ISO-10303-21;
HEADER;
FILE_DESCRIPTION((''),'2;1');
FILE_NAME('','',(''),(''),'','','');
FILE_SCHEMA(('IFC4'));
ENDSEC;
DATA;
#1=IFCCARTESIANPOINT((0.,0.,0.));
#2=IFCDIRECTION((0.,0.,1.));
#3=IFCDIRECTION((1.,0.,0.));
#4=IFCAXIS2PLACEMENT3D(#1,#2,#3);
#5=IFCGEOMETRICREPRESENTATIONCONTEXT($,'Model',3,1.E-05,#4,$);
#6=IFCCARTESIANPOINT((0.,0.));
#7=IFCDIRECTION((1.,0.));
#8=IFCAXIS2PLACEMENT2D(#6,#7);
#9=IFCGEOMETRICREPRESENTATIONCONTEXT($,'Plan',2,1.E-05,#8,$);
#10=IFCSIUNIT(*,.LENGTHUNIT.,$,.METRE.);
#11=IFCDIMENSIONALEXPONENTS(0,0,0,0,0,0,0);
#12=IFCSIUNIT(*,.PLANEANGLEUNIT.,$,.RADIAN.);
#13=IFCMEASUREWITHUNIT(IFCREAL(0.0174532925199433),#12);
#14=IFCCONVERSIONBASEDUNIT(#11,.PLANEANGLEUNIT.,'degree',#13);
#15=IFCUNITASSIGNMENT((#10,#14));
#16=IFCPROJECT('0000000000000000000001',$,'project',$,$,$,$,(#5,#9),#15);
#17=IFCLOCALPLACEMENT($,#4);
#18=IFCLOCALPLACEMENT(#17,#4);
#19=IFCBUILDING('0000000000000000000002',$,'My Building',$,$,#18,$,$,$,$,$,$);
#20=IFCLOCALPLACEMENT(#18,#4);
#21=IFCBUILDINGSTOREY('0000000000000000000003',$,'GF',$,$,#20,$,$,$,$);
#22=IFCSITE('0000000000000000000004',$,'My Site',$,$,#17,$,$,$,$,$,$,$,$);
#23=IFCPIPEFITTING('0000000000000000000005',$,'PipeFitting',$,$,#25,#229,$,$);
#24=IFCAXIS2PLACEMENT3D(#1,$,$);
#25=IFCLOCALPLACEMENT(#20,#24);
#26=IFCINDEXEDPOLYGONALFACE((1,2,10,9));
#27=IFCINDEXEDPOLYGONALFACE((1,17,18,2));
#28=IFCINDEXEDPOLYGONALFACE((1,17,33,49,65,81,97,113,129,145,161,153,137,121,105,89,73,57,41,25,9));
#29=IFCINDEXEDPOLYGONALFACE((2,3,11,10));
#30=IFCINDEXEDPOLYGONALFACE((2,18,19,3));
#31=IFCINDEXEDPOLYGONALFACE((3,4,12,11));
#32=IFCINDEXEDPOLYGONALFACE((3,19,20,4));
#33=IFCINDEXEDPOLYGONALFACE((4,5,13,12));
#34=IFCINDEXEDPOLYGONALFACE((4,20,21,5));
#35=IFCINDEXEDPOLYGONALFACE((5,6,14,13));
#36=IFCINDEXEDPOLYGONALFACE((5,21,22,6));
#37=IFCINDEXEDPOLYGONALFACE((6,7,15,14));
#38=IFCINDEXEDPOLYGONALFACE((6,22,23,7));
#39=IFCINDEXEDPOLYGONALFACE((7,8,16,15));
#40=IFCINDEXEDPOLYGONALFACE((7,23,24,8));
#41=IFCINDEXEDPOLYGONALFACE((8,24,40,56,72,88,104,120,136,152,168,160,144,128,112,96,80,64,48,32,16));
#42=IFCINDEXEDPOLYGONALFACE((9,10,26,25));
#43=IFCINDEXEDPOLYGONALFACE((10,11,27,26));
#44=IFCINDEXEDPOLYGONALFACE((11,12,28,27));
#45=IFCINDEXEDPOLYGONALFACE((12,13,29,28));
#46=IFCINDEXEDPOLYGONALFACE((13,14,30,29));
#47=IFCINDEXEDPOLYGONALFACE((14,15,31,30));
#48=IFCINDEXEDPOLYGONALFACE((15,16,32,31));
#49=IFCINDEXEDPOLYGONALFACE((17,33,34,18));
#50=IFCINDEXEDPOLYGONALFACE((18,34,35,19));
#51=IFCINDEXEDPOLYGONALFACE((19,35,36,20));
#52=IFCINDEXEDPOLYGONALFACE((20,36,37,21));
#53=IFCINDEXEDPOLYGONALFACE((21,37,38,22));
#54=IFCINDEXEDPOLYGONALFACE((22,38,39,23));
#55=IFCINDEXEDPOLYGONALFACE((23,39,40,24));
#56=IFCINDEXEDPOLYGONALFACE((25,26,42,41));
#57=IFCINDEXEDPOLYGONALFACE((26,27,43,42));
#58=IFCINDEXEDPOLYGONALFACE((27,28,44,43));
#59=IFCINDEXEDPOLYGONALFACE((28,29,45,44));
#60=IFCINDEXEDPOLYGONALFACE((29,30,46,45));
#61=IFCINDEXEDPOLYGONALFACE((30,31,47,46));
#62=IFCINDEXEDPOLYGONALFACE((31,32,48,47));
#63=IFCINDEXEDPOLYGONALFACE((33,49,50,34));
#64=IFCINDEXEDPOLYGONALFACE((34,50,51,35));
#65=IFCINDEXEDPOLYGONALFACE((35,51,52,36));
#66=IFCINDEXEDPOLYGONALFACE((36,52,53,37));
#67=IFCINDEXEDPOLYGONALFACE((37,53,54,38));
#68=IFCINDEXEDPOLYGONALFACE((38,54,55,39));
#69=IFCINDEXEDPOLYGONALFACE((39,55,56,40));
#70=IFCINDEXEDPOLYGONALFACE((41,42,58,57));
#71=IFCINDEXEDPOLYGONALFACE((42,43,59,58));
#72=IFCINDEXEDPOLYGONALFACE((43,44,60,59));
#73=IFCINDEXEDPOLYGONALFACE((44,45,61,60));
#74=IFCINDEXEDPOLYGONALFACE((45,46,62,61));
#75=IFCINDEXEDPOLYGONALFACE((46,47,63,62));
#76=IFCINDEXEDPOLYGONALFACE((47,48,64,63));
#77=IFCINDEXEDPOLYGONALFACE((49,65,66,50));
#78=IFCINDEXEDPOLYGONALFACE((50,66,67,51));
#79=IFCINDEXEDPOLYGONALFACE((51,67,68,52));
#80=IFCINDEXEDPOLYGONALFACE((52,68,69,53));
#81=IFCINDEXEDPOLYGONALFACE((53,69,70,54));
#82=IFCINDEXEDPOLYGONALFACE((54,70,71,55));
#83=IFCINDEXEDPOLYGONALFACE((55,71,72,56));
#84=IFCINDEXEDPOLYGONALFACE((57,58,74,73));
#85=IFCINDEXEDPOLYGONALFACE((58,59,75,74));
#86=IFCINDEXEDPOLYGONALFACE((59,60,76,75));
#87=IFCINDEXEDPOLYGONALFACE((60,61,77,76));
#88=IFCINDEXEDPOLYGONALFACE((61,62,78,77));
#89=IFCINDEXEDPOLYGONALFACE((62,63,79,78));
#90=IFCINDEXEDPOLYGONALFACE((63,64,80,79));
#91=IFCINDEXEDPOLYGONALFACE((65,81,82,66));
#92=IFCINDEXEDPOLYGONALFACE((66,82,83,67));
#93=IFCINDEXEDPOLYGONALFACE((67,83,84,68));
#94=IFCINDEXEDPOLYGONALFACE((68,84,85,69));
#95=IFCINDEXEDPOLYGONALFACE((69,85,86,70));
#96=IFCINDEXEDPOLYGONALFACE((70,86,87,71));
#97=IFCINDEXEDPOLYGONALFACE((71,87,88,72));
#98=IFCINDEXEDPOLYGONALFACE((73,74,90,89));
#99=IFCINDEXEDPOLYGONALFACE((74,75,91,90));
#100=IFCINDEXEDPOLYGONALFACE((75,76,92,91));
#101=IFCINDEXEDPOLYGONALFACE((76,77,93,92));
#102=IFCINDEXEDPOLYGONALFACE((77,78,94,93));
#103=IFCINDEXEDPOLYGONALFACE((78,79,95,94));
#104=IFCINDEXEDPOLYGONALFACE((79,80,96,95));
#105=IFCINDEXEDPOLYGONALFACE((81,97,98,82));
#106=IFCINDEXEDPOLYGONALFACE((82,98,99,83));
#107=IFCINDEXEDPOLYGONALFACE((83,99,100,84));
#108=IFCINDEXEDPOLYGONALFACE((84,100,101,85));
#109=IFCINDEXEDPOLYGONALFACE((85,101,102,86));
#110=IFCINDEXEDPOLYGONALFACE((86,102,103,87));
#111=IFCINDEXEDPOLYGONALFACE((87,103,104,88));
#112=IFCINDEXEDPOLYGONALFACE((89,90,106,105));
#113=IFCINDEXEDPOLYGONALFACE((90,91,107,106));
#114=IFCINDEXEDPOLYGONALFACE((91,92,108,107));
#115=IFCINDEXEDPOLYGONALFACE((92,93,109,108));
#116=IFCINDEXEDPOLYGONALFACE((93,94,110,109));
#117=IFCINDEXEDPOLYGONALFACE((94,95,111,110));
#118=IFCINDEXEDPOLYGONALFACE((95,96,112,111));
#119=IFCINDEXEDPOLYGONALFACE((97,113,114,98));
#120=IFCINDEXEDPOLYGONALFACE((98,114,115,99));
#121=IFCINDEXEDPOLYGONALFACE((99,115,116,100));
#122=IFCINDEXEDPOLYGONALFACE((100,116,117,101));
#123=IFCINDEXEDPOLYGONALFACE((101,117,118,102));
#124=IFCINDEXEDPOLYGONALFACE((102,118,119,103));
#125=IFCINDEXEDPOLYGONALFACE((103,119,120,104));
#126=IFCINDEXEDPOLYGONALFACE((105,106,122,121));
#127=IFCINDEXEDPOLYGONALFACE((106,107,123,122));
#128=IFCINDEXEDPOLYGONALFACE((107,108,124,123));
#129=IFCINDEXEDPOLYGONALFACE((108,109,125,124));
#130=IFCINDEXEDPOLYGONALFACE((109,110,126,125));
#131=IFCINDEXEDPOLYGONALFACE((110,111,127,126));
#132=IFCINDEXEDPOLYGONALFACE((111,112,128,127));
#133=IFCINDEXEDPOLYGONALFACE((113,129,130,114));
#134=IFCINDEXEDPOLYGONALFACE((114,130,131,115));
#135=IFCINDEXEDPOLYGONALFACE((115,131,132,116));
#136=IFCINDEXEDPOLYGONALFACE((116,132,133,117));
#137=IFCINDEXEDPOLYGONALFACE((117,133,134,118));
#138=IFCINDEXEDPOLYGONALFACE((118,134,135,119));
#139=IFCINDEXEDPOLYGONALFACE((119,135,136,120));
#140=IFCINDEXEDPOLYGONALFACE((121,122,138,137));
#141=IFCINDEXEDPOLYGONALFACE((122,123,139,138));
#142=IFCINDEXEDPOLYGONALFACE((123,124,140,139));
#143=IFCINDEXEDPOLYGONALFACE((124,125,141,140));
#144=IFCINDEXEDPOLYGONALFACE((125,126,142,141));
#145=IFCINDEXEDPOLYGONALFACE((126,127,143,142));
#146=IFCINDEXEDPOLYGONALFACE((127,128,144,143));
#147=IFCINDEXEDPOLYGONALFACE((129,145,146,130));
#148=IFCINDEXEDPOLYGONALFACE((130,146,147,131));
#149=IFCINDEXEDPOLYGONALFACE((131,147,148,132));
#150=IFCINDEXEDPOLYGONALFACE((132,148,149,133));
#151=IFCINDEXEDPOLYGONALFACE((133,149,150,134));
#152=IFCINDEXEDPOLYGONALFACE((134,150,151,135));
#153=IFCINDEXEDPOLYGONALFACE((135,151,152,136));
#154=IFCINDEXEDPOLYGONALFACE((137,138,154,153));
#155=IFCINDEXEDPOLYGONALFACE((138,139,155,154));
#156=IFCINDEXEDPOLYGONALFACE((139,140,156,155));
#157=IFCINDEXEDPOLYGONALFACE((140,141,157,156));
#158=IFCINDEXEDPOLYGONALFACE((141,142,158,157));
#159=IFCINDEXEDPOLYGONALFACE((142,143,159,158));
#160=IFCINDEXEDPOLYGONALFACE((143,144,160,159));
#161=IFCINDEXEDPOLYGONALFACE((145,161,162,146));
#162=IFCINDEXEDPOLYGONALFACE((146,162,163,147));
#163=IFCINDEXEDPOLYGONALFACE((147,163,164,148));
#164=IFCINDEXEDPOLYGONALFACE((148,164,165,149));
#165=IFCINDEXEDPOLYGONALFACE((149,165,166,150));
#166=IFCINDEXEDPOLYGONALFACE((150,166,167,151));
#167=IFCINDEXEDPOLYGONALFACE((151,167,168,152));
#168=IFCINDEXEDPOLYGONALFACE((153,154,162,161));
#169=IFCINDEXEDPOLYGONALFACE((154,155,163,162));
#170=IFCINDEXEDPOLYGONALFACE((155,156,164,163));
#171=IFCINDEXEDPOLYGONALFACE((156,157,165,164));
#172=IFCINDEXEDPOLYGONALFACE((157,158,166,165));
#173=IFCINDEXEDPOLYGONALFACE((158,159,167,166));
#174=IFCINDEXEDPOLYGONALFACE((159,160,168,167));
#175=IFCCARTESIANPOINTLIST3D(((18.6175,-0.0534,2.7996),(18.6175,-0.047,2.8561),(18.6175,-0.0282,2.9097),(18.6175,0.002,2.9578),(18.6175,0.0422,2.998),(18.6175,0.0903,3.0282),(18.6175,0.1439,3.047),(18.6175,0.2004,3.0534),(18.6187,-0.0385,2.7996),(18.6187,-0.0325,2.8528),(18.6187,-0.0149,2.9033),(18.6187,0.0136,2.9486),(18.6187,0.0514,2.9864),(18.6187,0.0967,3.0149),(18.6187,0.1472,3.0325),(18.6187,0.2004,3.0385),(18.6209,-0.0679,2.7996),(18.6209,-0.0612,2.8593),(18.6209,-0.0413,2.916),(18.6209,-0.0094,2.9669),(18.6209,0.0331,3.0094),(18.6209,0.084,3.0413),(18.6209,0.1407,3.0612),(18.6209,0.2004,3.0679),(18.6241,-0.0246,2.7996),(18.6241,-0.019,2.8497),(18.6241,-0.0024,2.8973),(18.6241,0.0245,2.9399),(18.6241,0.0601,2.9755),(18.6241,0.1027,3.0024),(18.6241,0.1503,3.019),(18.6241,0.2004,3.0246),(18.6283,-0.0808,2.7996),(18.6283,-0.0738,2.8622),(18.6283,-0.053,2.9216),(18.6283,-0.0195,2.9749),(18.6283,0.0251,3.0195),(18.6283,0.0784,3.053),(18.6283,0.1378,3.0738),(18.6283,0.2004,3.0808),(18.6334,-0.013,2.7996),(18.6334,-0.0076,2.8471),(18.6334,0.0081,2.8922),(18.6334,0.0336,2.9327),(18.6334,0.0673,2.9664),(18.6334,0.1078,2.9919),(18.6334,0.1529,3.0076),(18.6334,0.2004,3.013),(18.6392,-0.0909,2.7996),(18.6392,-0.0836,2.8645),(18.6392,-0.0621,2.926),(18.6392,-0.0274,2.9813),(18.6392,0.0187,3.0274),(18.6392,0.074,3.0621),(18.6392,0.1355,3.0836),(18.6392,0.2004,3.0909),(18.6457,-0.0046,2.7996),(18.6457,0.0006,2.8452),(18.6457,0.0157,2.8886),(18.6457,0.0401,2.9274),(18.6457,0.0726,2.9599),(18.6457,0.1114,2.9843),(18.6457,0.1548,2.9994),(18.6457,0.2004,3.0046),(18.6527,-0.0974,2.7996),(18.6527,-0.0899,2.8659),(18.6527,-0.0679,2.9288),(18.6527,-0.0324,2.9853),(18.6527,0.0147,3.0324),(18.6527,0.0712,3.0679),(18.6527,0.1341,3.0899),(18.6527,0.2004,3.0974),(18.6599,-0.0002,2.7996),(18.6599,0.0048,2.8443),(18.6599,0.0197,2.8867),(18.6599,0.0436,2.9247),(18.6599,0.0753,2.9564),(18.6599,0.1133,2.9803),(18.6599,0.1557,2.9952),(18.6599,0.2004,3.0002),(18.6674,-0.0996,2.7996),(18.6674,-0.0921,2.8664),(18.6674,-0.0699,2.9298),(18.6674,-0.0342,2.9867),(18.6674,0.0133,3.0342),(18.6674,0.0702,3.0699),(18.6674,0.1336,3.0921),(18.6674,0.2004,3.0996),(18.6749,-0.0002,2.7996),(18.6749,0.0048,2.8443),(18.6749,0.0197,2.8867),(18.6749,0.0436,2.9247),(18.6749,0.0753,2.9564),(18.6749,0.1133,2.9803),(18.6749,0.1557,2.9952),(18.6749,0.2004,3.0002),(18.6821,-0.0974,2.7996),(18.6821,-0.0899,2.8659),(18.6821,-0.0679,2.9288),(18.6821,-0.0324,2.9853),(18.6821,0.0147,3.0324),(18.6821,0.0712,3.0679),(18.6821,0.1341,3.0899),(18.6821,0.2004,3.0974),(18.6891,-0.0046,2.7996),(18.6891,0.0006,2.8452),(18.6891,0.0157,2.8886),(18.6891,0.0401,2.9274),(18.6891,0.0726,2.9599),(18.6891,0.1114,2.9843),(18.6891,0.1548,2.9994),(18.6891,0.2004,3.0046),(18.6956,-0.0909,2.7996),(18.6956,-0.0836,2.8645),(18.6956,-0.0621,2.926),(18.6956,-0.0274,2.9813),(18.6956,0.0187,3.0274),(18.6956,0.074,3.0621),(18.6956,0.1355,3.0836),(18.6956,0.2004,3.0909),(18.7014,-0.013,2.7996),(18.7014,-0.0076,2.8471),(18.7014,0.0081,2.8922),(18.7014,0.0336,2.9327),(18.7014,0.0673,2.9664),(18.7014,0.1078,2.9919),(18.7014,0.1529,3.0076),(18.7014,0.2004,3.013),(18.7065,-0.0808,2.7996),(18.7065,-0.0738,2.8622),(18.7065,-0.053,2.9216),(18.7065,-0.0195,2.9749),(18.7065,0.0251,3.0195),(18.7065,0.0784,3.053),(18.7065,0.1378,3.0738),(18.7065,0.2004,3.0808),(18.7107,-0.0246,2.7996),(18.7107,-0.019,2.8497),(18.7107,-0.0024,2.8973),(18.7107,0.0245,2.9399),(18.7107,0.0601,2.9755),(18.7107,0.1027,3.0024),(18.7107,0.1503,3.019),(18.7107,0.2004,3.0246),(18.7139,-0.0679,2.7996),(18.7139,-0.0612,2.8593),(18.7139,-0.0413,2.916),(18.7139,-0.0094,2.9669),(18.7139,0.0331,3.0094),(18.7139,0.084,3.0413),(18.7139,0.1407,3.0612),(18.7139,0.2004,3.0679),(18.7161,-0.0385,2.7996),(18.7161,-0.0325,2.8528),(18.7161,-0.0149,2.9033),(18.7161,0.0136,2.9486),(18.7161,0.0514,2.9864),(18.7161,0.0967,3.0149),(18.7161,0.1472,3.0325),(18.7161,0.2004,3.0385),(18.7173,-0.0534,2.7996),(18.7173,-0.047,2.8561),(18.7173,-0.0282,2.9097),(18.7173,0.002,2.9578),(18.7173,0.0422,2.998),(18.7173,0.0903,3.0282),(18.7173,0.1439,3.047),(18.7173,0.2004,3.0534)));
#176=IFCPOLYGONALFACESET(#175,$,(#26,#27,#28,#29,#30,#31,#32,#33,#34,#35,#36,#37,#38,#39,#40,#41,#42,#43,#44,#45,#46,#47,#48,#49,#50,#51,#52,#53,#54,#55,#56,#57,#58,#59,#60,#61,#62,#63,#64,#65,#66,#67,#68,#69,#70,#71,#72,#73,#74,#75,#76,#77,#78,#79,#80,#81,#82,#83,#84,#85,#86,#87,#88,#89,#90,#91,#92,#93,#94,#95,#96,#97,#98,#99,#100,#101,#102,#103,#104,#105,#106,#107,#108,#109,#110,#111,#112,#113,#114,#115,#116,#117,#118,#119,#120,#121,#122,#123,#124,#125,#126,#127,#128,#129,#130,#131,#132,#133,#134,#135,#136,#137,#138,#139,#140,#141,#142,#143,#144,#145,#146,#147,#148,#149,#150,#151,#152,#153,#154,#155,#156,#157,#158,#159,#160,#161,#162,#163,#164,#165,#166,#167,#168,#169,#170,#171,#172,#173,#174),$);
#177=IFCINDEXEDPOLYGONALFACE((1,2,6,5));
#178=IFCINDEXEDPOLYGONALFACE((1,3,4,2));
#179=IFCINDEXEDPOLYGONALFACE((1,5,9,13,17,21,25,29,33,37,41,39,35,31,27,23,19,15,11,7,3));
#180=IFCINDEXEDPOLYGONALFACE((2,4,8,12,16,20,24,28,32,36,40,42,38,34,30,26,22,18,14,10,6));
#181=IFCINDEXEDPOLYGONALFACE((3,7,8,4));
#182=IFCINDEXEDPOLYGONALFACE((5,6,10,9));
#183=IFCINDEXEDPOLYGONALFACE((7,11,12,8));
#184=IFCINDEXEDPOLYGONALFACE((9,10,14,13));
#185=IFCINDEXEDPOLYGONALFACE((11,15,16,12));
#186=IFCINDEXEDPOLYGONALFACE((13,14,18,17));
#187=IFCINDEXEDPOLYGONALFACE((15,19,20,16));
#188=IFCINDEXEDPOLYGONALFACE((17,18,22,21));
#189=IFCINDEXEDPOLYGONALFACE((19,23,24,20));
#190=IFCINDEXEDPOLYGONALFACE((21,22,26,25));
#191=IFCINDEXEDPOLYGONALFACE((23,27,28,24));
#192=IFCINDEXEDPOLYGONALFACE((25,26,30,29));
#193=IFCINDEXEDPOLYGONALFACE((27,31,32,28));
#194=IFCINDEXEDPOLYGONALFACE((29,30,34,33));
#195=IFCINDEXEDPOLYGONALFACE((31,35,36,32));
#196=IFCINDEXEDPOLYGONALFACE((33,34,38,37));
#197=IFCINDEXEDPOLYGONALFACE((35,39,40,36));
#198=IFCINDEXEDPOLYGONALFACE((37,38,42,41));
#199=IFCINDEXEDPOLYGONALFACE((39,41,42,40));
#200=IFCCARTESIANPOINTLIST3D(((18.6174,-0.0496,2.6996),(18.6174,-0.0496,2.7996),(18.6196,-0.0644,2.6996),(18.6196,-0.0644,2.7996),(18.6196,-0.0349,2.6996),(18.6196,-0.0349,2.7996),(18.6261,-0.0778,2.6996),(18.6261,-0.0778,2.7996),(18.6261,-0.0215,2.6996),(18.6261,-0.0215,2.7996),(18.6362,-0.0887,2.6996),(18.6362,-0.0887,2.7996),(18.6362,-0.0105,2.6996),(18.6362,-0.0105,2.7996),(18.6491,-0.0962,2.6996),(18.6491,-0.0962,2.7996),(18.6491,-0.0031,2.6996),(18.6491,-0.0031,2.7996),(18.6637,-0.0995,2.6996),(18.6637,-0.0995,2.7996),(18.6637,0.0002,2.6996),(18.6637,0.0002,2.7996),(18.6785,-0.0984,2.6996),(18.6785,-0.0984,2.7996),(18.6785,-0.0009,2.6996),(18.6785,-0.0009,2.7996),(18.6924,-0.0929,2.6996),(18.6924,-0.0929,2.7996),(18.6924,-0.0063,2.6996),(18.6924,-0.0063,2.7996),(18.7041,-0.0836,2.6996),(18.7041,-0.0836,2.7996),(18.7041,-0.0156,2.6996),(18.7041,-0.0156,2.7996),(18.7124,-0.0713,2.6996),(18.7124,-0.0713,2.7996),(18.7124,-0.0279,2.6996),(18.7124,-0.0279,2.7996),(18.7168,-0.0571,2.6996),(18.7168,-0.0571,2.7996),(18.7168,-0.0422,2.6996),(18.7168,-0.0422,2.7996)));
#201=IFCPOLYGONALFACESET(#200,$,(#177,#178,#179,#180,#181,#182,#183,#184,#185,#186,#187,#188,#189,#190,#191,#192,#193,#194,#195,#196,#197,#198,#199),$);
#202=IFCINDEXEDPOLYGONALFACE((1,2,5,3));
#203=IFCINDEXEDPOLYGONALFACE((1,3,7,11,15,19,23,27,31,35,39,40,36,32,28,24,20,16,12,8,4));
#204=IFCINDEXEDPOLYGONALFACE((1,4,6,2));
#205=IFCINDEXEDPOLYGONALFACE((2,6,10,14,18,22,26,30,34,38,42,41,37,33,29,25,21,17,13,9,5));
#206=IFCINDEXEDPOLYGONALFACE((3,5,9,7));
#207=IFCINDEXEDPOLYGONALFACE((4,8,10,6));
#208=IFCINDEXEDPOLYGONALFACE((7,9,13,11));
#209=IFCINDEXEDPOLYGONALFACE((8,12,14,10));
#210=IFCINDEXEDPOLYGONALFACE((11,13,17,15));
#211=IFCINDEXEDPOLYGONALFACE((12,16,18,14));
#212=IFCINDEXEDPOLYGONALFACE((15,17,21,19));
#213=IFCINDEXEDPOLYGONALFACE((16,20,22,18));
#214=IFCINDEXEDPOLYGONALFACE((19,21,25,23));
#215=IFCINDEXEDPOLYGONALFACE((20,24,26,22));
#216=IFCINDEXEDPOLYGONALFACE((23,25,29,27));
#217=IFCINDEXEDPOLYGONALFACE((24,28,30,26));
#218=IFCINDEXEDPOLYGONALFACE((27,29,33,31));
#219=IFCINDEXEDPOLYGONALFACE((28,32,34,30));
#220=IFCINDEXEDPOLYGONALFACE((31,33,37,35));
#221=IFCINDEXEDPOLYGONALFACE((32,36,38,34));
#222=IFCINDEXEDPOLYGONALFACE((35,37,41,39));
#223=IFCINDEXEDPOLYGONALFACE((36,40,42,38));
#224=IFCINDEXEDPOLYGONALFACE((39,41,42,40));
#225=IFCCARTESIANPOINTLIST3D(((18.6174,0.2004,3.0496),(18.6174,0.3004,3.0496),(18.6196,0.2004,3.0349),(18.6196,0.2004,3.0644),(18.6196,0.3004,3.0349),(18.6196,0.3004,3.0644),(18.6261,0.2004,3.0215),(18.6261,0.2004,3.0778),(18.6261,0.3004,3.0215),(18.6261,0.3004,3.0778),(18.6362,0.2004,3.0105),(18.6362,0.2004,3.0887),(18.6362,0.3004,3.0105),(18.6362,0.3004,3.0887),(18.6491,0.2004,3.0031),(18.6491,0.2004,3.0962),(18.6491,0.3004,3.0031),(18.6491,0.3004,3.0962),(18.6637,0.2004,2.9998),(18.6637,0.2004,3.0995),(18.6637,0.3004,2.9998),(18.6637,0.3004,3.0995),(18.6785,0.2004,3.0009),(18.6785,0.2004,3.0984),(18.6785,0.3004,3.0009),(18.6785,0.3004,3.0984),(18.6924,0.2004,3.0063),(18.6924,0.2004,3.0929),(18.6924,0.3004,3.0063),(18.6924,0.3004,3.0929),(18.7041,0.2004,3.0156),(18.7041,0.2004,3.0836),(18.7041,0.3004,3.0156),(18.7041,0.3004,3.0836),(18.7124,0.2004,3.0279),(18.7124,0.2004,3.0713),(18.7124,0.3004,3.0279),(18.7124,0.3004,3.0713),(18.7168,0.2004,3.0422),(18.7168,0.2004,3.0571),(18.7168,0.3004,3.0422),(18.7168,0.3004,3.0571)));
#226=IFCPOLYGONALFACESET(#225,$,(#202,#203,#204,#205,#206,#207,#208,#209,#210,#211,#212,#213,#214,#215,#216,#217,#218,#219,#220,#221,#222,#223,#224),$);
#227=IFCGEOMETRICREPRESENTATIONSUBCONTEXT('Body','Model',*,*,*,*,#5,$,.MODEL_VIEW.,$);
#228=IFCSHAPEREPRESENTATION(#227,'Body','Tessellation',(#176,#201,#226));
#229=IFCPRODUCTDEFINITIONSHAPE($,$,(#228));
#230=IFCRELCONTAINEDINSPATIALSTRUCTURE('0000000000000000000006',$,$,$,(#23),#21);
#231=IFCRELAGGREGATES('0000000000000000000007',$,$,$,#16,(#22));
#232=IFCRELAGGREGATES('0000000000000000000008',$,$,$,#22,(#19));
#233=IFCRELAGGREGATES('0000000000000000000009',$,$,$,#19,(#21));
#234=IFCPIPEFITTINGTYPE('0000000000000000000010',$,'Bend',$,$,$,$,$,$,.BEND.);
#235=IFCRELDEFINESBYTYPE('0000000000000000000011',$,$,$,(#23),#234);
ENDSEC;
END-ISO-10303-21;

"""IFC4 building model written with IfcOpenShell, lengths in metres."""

from ifc_helpers import new_model, entity, si_unit, converted_unit, frame, origin_with_axes, origin_2d_with_axis, place, context, subcontext, project, spatial, line, indexed_curve, circle, outline, extrude, source, transform, mapped, type_object, type_shapes, element, save


model = new_model("IFC4")

# Units and contexts
model_context = context("Model", 3, precision=1e-05, world=origin_with_axes())
plan_context = context("Plan", 2, precision=1e-05, world=origin_2d_with_axis())
body_context_1 = subcontext(model_context, "Body", "Model", "MODEL_VIEW")
ifc_project = project(units=[si_unit("LENGTHUNIT", "METRE"), converted_unit("PLANEANGLEUNIT", "degree", entity("IfcReal", 0.0174532925199433), si_unit("PLANEANGLEUNIT", "RADIAN"), dimensions=[0, 0, 0, 0, 0, 0, 0])], contexts=[model_context, plan_context])

# Site, building, storey
site_placement = place(None, origin_with_axes())
site = spatial("IfcSite", under=ifc_project, at=site_placement, Name="My Site")
building_placement = place(site_placement, origin_with_axes())
building = spatial("IfcBuilding", under=site, at=building_placement, Name="My Building")
storey_placement = place(building_placement, origin_with_axes())
storey = spatial("IfcBuildingStorey", under=building, at=storey_placement, Name="GF")

# Pipe fitting, opening
pipe_fitting_type = type_object("IfcPipeFittingType", Name="Bend", PredefinedType="BEND")
shared_shape_1 = source(origin_with_axes(), body_context_1, "Body", "SolidModel", [
    entity("IfcSweptDiskSolid", entity("IfcIndexedPolyCurve", entity("IfcCartesianPointList3D", [[0.0, 0.0, 0.1], [0.0, -0.0732, 0.2768], [0.0, -0.25, 0.35]]), [entity("IfcArcIndex", [1, 2, 3])]), 0.05),
    extrude(circle(Radius=0.05), origin_with_axes(), (0.0, 0.0, 1.0), 0.1),
    extrude(circle(Radius=0.05), frame((0.0, -0.25, 0.35), z_axis=(0.0, -1.0, 0.0), x_axis=(1.0, 0.0, 0.0)), (0.0, 0.0, 1.0), 0.1),
])
type_shapes(pipe_fitting_type, [shared_shape_1])
pipe_fitting_1_placement = place(storey_placement, frame((18.6674, -0.0496, 2.6996), z_axis=(0.0, 0.0, 1.0), x_axis=(-1.0, 0.0, 0.0)))
pipe_fitting_1 = element("IfcPipeFitting", 1, at=pipe_fitting_1_placement, inside=storey, type_object=pipe_fitting_type, Name="PipeFitting", context=body_context_1, shape_type="MappedRepresentation", body=[
    mapped(shared_shape_1, transform((0.0, 0.0, 0.0), x_axis=(1.0, 0.0, 0.0), y_axis=(0.0, 1.0, 0.0), z_axis=(0.0, 0.0, 1.0), scale=1.0)),
])
opening_1_placement = place(pipe_fitting_1_placement, frame((18.6674, -0.0496, -2.6996), z_axis=(0.0, 0.0, 1.0), x_axis=(-1.0, 0.0, 0.0)))
element("IfcOpeningElement", 2, at=opening_1_placement, cuts=pipe_fitting_1, PredefinedType="OPENING", context=body_context_1, shape_type="SweptSolid", body=[
    extrude(outline(indexed_curve([(0.0, 0.0), (0.5, 0.0), (0.5, 0.5), (0.0, 0.5)], segments=[line(1, 2, 3, 4, 1)])), origin_with_axes(), (0.0, 0.0, 1.0), 0.5),
])

save(model, "model.ifc")
